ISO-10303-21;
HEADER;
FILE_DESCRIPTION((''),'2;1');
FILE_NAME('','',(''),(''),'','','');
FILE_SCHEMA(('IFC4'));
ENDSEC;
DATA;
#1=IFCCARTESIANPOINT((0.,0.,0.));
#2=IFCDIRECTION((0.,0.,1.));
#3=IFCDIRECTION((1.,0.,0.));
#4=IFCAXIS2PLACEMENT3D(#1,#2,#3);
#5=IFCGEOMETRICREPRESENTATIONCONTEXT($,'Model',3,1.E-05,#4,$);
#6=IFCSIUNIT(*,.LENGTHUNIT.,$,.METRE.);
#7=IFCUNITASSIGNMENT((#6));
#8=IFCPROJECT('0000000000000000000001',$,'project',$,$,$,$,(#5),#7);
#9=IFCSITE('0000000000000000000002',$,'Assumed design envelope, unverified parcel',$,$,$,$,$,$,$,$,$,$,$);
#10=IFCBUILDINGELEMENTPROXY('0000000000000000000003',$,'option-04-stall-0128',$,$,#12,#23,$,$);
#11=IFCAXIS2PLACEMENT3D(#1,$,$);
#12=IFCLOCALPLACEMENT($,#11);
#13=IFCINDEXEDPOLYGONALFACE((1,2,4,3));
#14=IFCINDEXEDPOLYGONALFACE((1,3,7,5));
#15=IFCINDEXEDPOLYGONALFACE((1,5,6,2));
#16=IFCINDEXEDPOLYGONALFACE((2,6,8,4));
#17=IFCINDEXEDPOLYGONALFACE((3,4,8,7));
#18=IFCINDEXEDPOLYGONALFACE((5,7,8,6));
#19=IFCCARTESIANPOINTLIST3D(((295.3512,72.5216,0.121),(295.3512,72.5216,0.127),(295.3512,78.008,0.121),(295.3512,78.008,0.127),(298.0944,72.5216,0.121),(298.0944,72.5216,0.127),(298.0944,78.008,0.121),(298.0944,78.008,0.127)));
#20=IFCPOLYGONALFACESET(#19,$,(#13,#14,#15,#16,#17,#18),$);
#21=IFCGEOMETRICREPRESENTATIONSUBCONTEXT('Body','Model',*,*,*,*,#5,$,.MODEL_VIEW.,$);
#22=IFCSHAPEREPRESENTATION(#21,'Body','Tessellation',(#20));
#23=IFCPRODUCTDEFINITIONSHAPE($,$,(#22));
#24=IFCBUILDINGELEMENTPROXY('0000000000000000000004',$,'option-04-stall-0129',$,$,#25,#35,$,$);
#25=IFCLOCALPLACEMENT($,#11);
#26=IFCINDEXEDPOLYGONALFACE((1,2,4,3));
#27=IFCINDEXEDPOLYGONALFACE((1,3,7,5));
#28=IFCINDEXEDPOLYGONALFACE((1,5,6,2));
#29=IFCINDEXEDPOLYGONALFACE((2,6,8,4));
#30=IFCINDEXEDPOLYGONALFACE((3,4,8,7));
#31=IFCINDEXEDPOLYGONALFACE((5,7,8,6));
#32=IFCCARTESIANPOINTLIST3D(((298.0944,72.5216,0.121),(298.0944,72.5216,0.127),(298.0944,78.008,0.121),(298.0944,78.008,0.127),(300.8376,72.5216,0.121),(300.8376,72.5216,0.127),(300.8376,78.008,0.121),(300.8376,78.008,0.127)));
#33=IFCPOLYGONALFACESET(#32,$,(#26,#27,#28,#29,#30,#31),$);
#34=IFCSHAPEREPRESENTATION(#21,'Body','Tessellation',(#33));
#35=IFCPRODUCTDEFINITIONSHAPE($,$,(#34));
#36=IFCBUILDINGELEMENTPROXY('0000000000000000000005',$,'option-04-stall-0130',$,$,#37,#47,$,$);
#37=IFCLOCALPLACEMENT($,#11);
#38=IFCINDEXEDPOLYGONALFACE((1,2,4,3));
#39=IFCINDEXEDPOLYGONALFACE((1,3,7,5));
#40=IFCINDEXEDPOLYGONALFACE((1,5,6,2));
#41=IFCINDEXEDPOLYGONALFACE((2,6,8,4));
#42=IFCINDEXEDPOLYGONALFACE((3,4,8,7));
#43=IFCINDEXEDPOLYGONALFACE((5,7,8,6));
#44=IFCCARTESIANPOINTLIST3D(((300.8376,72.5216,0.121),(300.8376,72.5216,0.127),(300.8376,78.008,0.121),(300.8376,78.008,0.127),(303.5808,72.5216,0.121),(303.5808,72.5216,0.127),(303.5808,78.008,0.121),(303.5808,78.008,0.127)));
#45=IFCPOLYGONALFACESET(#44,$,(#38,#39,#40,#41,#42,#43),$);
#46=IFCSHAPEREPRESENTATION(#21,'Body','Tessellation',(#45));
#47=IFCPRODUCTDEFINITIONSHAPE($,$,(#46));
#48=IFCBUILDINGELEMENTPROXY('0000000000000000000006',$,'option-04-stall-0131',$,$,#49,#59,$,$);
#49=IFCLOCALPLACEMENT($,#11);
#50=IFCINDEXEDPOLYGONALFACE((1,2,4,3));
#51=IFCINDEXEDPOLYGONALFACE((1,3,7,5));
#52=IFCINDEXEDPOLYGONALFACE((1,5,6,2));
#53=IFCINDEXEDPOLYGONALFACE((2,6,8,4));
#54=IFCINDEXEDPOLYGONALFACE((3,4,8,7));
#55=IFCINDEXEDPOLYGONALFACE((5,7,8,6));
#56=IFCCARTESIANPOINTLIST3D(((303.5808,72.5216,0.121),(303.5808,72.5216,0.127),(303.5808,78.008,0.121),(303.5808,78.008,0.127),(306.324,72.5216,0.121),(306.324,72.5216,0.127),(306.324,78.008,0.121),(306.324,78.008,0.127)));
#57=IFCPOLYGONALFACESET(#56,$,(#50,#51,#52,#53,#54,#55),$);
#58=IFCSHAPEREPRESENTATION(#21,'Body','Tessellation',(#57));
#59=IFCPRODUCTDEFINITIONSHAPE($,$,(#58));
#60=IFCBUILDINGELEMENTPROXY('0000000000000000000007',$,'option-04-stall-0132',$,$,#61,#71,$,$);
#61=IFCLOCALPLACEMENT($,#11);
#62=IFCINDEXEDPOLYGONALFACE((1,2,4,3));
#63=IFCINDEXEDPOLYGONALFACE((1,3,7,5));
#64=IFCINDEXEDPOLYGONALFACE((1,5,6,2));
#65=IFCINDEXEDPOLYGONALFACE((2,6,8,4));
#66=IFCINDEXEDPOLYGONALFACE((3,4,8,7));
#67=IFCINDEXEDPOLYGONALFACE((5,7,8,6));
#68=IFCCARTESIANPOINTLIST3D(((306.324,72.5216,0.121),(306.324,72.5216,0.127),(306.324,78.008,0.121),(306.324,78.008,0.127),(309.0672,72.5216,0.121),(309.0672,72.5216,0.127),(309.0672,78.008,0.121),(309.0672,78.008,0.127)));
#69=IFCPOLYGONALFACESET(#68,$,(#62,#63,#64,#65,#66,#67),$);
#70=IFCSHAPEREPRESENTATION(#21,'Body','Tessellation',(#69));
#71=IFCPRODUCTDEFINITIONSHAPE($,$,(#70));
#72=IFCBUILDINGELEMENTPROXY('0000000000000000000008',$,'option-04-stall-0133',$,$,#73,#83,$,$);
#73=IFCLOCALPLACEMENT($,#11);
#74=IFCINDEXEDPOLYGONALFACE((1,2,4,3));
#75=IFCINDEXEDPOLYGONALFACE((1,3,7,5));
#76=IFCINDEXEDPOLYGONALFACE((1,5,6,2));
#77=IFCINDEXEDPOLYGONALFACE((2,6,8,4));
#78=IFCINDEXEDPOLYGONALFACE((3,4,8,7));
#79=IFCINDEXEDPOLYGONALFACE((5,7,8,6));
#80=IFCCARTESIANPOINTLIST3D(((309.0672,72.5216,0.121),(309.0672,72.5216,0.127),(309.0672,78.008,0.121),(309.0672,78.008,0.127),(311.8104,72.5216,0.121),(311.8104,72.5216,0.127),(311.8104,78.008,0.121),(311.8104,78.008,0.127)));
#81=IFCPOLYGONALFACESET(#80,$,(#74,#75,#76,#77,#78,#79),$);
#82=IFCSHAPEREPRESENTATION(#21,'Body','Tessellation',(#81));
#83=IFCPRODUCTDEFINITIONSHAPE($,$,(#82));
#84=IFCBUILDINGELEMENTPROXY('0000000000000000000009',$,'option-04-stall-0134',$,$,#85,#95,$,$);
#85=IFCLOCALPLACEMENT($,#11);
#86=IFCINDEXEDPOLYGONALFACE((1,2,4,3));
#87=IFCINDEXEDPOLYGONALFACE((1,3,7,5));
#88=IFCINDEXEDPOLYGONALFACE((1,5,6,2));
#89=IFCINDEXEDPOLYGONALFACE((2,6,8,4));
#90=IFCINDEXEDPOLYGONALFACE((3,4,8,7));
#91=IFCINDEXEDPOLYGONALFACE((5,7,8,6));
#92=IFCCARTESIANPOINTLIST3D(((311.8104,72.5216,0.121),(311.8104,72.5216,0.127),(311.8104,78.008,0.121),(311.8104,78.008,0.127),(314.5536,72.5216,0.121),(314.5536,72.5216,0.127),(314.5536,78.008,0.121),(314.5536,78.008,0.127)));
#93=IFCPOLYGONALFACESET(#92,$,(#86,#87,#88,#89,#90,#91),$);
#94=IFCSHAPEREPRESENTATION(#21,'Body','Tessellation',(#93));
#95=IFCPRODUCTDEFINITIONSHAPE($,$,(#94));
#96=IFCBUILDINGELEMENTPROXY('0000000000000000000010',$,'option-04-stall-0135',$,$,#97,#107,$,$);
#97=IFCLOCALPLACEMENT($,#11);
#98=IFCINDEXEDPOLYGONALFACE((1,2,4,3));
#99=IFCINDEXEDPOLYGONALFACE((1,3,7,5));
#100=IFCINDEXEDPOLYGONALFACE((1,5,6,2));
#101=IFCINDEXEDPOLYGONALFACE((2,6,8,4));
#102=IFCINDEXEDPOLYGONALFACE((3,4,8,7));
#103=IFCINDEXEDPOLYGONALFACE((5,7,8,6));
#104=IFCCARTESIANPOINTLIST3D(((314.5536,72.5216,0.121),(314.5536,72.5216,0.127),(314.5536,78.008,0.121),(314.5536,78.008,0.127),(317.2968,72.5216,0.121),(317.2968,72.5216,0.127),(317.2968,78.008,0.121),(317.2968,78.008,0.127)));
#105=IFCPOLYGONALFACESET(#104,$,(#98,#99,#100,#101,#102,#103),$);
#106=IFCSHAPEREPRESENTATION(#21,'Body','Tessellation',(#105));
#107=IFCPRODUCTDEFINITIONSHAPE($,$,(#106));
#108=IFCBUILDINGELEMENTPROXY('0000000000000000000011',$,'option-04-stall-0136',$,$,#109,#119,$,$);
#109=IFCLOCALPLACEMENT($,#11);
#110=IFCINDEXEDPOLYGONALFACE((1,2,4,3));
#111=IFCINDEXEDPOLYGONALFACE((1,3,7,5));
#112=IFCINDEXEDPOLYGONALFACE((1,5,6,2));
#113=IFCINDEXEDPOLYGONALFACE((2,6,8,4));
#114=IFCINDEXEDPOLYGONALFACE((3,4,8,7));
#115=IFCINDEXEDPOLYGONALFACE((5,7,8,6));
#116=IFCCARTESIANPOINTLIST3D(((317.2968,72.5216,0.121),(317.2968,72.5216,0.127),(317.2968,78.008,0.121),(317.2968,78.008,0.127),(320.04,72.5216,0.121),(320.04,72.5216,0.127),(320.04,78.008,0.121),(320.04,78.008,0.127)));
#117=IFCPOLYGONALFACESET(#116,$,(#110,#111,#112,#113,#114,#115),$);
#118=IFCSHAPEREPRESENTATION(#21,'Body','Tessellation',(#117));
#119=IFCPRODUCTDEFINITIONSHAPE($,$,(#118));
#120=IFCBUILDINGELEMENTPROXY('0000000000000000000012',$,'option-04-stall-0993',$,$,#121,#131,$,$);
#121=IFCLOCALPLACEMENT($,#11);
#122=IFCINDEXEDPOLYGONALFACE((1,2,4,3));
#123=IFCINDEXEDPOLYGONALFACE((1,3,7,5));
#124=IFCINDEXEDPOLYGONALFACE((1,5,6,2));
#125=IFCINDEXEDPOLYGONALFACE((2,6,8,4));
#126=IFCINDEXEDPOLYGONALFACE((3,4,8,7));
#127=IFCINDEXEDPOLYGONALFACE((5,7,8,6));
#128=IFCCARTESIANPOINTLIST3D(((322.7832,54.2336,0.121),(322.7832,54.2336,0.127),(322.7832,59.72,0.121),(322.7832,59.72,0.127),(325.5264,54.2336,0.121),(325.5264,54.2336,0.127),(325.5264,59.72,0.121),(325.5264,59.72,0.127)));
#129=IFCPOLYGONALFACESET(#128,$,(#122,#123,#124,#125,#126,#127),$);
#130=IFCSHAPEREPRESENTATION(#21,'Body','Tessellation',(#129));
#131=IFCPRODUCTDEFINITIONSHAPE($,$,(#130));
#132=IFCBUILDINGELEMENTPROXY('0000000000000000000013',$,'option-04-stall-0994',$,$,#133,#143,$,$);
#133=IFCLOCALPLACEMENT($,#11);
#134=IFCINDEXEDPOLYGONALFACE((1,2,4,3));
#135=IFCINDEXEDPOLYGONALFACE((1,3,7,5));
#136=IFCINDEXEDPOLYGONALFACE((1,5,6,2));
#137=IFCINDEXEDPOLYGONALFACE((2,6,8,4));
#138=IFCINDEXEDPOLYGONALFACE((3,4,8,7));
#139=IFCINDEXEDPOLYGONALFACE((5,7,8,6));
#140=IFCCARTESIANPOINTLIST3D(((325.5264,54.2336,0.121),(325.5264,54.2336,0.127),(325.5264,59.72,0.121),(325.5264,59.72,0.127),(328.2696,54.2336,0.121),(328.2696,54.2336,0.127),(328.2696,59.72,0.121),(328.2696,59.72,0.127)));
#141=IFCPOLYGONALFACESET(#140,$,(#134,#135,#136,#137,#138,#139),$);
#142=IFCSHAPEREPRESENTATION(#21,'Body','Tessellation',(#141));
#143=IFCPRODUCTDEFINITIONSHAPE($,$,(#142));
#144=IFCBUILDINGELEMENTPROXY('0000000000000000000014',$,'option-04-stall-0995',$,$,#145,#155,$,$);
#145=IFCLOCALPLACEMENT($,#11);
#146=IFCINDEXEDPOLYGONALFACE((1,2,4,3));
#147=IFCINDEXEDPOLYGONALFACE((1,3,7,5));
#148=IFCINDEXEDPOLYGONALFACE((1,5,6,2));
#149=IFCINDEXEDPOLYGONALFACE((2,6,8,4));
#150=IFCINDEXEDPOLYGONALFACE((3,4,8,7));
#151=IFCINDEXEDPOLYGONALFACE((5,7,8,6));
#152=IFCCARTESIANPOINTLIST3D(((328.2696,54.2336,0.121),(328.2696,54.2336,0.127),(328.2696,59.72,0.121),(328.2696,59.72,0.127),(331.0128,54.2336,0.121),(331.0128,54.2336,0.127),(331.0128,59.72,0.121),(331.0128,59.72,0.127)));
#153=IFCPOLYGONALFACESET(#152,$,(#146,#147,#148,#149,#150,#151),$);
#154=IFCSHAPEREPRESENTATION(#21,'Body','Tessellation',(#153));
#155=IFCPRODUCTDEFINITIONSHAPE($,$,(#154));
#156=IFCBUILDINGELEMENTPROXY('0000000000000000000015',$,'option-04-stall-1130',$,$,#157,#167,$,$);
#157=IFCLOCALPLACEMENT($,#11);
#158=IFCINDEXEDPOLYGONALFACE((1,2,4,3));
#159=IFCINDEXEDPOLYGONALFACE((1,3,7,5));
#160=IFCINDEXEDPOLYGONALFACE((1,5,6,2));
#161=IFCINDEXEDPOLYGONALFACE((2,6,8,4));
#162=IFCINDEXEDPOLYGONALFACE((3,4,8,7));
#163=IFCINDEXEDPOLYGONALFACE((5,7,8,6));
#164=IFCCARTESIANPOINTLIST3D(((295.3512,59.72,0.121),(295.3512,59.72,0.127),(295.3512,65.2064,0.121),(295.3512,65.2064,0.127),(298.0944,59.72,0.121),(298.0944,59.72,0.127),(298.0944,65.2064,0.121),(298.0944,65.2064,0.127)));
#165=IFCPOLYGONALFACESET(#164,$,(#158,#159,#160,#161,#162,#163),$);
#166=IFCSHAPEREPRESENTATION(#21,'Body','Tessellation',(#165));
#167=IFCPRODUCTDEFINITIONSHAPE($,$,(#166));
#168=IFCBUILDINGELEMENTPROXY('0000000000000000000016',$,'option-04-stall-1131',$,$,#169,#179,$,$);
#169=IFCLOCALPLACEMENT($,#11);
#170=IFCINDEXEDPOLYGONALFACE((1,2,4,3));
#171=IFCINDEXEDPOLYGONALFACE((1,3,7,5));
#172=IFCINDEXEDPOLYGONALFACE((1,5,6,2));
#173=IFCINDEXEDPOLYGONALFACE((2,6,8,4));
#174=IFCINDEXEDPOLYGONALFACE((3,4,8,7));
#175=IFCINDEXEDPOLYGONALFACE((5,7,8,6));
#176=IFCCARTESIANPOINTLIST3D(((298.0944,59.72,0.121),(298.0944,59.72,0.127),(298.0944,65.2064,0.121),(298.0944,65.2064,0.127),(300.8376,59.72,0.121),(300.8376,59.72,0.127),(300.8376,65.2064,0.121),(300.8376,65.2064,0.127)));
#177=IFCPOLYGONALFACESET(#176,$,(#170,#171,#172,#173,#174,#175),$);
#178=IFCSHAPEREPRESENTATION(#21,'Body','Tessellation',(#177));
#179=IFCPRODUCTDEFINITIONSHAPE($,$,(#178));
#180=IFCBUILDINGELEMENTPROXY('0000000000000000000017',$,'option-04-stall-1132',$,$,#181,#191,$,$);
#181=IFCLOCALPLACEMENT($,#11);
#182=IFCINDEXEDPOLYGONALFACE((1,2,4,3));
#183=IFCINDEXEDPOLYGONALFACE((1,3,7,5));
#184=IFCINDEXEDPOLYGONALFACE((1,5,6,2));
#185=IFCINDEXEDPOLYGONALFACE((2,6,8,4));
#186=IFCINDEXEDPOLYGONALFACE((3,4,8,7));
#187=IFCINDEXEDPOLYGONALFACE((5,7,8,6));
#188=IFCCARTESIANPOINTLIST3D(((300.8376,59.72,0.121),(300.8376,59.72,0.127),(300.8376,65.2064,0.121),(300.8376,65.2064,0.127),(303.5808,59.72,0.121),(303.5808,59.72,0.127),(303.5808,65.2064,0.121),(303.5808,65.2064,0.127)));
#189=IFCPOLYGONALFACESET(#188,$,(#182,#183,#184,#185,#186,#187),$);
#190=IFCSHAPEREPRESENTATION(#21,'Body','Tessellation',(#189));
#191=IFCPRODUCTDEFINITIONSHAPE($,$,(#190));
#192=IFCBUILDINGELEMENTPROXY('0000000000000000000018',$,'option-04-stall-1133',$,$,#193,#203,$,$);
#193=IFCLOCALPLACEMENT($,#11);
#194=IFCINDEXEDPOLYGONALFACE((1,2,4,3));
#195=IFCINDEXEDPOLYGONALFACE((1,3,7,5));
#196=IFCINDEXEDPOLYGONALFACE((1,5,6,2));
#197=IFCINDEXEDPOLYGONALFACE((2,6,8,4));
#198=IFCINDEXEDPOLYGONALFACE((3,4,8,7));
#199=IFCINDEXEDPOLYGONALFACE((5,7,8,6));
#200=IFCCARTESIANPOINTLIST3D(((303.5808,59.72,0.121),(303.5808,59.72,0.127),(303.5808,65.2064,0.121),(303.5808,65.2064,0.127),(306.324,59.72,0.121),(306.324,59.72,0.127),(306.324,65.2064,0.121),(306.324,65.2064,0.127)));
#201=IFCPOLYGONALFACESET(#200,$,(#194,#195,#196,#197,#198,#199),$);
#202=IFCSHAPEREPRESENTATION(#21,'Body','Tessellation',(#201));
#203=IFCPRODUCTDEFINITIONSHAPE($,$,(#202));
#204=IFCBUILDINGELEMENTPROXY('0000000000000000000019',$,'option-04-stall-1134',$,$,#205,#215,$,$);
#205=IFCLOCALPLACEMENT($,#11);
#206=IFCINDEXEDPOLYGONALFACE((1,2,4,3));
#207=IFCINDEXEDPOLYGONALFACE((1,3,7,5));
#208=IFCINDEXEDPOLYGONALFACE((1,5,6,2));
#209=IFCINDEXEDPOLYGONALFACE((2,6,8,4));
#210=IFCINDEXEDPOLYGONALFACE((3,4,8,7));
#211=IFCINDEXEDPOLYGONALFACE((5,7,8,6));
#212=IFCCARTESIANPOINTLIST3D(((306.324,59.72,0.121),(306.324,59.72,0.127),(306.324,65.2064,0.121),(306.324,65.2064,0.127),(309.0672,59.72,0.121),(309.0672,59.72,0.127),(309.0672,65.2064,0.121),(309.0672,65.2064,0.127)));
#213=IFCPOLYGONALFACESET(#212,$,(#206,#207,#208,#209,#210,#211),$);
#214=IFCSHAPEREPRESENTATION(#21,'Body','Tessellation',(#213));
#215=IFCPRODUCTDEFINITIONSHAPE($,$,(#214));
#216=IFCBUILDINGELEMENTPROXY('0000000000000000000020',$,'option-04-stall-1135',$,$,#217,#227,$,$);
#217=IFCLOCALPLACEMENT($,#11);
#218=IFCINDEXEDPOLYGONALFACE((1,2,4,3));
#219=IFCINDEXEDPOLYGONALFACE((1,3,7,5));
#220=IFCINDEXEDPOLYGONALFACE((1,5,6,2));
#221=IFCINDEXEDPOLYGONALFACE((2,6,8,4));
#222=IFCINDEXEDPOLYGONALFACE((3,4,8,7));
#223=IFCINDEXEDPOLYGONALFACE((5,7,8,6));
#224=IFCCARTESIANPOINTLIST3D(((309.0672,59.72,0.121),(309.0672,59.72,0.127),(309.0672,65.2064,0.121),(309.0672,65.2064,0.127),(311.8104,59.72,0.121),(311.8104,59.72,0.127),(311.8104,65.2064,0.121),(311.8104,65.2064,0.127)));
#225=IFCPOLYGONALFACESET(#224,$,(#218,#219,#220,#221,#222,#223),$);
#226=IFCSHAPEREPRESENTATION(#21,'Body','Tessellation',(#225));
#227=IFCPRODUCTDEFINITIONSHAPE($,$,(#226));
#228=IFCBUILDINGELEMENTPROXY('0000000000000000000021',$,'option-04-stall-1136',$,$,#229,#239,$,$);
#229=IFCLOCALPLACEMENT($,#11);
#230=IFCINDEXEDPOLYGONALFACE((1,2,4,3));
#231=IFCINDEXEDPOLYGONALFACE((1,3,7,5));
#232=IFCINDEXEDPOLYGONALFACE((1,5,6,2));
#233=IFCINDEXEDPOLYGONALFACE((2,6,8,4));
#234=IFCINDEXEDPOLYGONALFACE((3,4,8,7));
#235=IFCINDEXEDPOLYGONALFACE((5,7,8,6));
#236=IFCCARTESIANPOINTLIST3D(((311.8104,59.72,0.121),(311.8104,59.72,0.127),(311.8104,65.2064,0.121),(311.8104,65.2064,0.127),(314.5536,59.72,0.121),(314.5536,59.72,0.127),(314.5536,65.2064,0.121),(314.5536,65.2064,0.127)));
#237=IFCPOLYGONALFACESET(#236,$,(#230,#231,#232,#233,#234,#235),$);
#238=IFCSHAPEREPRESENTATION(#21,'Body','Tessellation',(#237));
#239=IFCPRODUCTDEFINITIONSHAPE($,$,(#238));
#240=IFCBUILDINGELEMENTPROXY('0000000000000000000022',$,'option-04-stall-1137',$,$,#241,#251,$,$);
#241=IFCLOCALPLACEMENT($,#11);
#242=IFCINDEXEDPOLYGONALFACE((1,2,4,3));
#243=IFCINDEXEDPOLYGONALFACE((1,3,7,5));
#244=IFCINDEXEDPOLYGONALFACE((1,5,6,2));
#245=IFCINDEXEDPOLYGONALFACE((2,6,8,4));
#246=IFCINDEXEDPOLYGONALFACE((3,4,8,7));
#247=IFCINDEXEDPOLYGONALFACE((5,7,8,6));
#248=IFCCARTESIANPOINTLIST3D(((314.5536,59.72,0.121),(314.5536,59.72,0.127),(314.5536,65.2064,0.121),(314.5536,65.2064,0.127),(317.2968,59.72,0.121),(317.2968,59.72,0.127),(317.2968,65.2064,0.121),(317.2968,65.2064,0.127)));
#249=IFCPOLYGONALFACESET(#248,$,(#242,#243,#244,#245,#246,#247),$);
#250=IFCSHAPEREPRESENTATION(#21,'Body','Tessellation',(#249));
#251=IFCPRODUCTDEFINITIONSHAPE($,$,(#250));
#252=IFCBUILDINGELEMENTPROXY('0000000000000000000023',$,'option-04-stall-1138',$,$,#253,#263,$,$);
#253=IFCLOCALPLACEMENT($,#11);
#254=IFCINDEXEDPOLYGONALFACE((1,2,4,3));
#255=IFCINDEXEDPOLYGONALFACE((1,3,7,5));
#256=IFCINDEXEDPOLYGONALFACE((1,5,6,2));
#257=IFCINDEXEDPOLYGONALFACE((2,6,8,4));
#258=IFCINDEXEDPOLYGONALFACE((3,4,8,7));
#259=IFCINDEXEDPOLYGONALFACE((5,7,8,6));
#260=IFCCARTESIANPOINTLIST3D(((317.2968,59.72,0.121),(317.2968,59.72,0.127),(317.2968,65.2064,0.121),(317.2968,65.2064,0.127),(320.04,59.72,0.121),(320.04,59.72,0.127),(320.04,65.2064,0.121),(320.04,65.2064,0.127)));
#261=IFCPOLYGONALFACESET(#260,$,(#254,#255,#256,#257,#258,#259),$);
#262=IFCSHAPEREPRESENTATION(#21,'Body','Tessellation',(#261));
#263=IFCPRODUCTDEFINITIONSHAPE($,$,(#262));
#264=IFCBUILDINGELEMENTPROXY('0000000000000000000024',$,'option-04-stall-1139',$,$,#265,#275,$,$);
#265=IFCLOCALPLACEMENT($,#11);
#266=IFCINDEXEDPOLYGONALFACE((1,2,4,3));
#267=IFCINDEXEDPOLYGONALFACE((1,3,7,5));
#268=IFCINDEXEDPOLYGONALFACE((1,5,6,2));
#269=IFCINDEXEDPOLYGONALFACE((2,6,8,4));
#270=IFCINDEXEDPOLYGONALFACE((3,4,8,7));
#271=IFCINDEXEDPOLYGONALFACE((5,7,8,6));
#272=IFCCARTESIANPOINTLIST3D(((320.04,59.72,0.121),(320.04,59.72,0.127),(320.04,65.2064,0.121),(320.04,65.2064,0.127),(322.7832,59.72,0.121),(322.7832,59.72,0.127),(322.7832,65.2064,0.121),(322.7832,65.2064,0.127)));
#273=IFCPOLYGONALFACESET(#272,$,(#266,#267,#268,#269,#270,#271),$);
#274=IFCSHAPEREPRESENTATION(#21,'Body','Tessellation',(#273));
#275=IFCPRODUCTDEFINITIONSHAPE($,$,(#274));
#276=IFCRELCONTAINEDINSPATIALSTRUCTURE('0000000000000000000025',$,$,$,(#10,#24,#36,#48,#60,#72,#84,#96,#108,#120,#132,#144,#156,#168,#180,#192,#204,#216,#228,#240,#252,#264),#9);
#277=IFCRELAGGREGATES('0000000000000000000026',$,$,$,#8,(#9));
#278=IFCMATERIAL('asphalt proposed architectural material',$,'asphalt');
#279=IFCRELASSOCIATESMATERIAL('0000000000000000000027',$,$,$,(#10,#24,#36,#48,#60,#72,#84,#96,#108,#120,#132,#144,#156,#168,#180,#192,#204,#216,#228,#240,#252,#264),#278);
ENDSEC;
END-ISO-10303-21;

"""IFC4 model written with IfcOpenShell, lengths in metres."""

from ifc_helpers import new_model, si_unit, frame, origin_with_axes, place, context, subcontext, project, spatial, rectangle, extrude, material, element, save


model = new_model("IFC4")

# Units and contexts
model_context = context("Model", 3, precision=1e-05, world=origin_with_axes())
body_context = subcontext(model_context, "Body", "Model", "MODEL_VIEW")
ifc_project = project(units=[si_unit("LENGTHUNIT", "METRE")], contexts=[model_context])

# Site
site = spatial("IfcSite", under=ifc_project, Name="Assumed design envelope, unverified parcel")

# Building element proxies
ifc_material = material(Name="asphalt proposed architectural material", Category="asphalt")
for number, where, z_axis, x_axis, name in (
    (1, (296.7228, 75.2648, 0.121), (0.0, 0.0, 1.0), (1.0, 0.0, 0.0), "option-04-stall-0128"),
    (2, (299.466, 75.2648, 0.121), (0.0, 0.0, 1.0), (1.0, 0.0, 0.0), "option-04-stall-0129"),
    (3, (302.2092, 75.2648, 0.121), (0.0, 0.0, 1.0), (1.0, 0.0, 0.0), "option-04-stall-0130"),
    (4, (304.9524, 75.2648, 0.121), (0.0, 0.0, 1.0), (1.0, 0.0, 0.0), "option-04-stall-0131"),
    (5, (307.6956, 75.2648, 0.121), (0.0, 0.0, 1.0), (1.0, 0.0, 0.0), "option-04-stall-0132"),
    (6, (310.4388, 75.2648, 0.121), (0.0, 0.0, 1.0), (1.0, 0.0, 0.0), "option-04-stall-0133"),
    (7, (313.182, 75.2648, 0.121), (0.0, 0.0, 1.0), (1.0, 0.0, 0.0), "option-04-stall-0134"),
    (8, (315.9252, 75.2648, 0.121), (0.0, 0.0, 1.0), (1.0, 0.0, 0.0), "option-04-stall-0135"),
    (9, (318.6684, 75.2648, 0.121), (0.0, 0.0, 1.0), (1.0, 0.0, 0.0), "option-04-stall-0136"),
    (10, (324.1548, 56.9768, 0.121), (0.0, 0.0, 1.0), (1.0, 0.0, 0.0), "option-04-stall-0993"),
    (11, (326.898, 56.9768, 0.121), (0.0, 0.0, 1.0), (1.0, 0.0, 0.0), "option-04-stall-0994"),
    (12, (329.6412, 56.9768, 0.121), (0.0, 0.0, 1.0), (1.0, 0.0, 0.0), "option-04-stall-0995"),
    (13, (296.7228, 62.4632, 0.121), (0.0, 0.0, 1.0), (1.0, 0.0, 0.0), "option-04-stall-1130"),
    (14, (299.466, 62.4632, 0.121), (0.0, 0.0, 1.0), (1.0, 0.0, 0.0), "option-04-stall-1131"),
    (15, (302.2092, 62.4632, 0.121), (0.0, 0.0, 1.0), (1.0, 0.0, 0.0), "option-04-stall-1132"),
    (16, (304.9524, 62.4632, 0.121), (0.0, 0.0, 1.0), (1.0, 0.0, 0.0), "option-04-stall-1133"),
    (17, (307.6956, 62.4632, 0.121), (0.0, 0.0, 1.0), (1.0, 0.0, 0.0), "option-04-stall-1134"),
    (18, (310.4388, 62.4632, 0.121), (0.0, 0.0, 1.0), (1.0, 0.0, 0.0), "option-04-stall-1135"),
    (19, (313.182, 62.4632, 0.121), (0.0, 0.0, 1.0), (1.0, 0.0, 0.0), "option-04-stall-1136"),
    (20, (315.9252, 62.4632, 0.121), (0.0, 0.0, 1.0), (1.0, 0.0, 0.0), "option-04-stall-1137"),
    (21, (318.6684, 62.4632, 0.121), (0.0, 0.0, 1.0), (1.0, 0.0, 0.0), "option-04-stall-1138"),
    (22, (321.4116, 62.4632, 0.121), (0.0, 0.0, 1.0), (1.0, 0.0, 0.0), "option-04-stall-1139"),
):
    element("IfcBuildingElementProxy", number, at=place(None, frame(where, z_axis=z_axis, x_axis=x_axis)), inside=site, material=ifc_material, Name=name, context=body_context, shape_type="SweptSolid", body=[
        extrude(rectangle(XDim=2.7432, YDim=5.4864), origin_with_axes(), (0.0, 0.0, 1.0), 0.006),
    ])

save(model, "model.ifc")
